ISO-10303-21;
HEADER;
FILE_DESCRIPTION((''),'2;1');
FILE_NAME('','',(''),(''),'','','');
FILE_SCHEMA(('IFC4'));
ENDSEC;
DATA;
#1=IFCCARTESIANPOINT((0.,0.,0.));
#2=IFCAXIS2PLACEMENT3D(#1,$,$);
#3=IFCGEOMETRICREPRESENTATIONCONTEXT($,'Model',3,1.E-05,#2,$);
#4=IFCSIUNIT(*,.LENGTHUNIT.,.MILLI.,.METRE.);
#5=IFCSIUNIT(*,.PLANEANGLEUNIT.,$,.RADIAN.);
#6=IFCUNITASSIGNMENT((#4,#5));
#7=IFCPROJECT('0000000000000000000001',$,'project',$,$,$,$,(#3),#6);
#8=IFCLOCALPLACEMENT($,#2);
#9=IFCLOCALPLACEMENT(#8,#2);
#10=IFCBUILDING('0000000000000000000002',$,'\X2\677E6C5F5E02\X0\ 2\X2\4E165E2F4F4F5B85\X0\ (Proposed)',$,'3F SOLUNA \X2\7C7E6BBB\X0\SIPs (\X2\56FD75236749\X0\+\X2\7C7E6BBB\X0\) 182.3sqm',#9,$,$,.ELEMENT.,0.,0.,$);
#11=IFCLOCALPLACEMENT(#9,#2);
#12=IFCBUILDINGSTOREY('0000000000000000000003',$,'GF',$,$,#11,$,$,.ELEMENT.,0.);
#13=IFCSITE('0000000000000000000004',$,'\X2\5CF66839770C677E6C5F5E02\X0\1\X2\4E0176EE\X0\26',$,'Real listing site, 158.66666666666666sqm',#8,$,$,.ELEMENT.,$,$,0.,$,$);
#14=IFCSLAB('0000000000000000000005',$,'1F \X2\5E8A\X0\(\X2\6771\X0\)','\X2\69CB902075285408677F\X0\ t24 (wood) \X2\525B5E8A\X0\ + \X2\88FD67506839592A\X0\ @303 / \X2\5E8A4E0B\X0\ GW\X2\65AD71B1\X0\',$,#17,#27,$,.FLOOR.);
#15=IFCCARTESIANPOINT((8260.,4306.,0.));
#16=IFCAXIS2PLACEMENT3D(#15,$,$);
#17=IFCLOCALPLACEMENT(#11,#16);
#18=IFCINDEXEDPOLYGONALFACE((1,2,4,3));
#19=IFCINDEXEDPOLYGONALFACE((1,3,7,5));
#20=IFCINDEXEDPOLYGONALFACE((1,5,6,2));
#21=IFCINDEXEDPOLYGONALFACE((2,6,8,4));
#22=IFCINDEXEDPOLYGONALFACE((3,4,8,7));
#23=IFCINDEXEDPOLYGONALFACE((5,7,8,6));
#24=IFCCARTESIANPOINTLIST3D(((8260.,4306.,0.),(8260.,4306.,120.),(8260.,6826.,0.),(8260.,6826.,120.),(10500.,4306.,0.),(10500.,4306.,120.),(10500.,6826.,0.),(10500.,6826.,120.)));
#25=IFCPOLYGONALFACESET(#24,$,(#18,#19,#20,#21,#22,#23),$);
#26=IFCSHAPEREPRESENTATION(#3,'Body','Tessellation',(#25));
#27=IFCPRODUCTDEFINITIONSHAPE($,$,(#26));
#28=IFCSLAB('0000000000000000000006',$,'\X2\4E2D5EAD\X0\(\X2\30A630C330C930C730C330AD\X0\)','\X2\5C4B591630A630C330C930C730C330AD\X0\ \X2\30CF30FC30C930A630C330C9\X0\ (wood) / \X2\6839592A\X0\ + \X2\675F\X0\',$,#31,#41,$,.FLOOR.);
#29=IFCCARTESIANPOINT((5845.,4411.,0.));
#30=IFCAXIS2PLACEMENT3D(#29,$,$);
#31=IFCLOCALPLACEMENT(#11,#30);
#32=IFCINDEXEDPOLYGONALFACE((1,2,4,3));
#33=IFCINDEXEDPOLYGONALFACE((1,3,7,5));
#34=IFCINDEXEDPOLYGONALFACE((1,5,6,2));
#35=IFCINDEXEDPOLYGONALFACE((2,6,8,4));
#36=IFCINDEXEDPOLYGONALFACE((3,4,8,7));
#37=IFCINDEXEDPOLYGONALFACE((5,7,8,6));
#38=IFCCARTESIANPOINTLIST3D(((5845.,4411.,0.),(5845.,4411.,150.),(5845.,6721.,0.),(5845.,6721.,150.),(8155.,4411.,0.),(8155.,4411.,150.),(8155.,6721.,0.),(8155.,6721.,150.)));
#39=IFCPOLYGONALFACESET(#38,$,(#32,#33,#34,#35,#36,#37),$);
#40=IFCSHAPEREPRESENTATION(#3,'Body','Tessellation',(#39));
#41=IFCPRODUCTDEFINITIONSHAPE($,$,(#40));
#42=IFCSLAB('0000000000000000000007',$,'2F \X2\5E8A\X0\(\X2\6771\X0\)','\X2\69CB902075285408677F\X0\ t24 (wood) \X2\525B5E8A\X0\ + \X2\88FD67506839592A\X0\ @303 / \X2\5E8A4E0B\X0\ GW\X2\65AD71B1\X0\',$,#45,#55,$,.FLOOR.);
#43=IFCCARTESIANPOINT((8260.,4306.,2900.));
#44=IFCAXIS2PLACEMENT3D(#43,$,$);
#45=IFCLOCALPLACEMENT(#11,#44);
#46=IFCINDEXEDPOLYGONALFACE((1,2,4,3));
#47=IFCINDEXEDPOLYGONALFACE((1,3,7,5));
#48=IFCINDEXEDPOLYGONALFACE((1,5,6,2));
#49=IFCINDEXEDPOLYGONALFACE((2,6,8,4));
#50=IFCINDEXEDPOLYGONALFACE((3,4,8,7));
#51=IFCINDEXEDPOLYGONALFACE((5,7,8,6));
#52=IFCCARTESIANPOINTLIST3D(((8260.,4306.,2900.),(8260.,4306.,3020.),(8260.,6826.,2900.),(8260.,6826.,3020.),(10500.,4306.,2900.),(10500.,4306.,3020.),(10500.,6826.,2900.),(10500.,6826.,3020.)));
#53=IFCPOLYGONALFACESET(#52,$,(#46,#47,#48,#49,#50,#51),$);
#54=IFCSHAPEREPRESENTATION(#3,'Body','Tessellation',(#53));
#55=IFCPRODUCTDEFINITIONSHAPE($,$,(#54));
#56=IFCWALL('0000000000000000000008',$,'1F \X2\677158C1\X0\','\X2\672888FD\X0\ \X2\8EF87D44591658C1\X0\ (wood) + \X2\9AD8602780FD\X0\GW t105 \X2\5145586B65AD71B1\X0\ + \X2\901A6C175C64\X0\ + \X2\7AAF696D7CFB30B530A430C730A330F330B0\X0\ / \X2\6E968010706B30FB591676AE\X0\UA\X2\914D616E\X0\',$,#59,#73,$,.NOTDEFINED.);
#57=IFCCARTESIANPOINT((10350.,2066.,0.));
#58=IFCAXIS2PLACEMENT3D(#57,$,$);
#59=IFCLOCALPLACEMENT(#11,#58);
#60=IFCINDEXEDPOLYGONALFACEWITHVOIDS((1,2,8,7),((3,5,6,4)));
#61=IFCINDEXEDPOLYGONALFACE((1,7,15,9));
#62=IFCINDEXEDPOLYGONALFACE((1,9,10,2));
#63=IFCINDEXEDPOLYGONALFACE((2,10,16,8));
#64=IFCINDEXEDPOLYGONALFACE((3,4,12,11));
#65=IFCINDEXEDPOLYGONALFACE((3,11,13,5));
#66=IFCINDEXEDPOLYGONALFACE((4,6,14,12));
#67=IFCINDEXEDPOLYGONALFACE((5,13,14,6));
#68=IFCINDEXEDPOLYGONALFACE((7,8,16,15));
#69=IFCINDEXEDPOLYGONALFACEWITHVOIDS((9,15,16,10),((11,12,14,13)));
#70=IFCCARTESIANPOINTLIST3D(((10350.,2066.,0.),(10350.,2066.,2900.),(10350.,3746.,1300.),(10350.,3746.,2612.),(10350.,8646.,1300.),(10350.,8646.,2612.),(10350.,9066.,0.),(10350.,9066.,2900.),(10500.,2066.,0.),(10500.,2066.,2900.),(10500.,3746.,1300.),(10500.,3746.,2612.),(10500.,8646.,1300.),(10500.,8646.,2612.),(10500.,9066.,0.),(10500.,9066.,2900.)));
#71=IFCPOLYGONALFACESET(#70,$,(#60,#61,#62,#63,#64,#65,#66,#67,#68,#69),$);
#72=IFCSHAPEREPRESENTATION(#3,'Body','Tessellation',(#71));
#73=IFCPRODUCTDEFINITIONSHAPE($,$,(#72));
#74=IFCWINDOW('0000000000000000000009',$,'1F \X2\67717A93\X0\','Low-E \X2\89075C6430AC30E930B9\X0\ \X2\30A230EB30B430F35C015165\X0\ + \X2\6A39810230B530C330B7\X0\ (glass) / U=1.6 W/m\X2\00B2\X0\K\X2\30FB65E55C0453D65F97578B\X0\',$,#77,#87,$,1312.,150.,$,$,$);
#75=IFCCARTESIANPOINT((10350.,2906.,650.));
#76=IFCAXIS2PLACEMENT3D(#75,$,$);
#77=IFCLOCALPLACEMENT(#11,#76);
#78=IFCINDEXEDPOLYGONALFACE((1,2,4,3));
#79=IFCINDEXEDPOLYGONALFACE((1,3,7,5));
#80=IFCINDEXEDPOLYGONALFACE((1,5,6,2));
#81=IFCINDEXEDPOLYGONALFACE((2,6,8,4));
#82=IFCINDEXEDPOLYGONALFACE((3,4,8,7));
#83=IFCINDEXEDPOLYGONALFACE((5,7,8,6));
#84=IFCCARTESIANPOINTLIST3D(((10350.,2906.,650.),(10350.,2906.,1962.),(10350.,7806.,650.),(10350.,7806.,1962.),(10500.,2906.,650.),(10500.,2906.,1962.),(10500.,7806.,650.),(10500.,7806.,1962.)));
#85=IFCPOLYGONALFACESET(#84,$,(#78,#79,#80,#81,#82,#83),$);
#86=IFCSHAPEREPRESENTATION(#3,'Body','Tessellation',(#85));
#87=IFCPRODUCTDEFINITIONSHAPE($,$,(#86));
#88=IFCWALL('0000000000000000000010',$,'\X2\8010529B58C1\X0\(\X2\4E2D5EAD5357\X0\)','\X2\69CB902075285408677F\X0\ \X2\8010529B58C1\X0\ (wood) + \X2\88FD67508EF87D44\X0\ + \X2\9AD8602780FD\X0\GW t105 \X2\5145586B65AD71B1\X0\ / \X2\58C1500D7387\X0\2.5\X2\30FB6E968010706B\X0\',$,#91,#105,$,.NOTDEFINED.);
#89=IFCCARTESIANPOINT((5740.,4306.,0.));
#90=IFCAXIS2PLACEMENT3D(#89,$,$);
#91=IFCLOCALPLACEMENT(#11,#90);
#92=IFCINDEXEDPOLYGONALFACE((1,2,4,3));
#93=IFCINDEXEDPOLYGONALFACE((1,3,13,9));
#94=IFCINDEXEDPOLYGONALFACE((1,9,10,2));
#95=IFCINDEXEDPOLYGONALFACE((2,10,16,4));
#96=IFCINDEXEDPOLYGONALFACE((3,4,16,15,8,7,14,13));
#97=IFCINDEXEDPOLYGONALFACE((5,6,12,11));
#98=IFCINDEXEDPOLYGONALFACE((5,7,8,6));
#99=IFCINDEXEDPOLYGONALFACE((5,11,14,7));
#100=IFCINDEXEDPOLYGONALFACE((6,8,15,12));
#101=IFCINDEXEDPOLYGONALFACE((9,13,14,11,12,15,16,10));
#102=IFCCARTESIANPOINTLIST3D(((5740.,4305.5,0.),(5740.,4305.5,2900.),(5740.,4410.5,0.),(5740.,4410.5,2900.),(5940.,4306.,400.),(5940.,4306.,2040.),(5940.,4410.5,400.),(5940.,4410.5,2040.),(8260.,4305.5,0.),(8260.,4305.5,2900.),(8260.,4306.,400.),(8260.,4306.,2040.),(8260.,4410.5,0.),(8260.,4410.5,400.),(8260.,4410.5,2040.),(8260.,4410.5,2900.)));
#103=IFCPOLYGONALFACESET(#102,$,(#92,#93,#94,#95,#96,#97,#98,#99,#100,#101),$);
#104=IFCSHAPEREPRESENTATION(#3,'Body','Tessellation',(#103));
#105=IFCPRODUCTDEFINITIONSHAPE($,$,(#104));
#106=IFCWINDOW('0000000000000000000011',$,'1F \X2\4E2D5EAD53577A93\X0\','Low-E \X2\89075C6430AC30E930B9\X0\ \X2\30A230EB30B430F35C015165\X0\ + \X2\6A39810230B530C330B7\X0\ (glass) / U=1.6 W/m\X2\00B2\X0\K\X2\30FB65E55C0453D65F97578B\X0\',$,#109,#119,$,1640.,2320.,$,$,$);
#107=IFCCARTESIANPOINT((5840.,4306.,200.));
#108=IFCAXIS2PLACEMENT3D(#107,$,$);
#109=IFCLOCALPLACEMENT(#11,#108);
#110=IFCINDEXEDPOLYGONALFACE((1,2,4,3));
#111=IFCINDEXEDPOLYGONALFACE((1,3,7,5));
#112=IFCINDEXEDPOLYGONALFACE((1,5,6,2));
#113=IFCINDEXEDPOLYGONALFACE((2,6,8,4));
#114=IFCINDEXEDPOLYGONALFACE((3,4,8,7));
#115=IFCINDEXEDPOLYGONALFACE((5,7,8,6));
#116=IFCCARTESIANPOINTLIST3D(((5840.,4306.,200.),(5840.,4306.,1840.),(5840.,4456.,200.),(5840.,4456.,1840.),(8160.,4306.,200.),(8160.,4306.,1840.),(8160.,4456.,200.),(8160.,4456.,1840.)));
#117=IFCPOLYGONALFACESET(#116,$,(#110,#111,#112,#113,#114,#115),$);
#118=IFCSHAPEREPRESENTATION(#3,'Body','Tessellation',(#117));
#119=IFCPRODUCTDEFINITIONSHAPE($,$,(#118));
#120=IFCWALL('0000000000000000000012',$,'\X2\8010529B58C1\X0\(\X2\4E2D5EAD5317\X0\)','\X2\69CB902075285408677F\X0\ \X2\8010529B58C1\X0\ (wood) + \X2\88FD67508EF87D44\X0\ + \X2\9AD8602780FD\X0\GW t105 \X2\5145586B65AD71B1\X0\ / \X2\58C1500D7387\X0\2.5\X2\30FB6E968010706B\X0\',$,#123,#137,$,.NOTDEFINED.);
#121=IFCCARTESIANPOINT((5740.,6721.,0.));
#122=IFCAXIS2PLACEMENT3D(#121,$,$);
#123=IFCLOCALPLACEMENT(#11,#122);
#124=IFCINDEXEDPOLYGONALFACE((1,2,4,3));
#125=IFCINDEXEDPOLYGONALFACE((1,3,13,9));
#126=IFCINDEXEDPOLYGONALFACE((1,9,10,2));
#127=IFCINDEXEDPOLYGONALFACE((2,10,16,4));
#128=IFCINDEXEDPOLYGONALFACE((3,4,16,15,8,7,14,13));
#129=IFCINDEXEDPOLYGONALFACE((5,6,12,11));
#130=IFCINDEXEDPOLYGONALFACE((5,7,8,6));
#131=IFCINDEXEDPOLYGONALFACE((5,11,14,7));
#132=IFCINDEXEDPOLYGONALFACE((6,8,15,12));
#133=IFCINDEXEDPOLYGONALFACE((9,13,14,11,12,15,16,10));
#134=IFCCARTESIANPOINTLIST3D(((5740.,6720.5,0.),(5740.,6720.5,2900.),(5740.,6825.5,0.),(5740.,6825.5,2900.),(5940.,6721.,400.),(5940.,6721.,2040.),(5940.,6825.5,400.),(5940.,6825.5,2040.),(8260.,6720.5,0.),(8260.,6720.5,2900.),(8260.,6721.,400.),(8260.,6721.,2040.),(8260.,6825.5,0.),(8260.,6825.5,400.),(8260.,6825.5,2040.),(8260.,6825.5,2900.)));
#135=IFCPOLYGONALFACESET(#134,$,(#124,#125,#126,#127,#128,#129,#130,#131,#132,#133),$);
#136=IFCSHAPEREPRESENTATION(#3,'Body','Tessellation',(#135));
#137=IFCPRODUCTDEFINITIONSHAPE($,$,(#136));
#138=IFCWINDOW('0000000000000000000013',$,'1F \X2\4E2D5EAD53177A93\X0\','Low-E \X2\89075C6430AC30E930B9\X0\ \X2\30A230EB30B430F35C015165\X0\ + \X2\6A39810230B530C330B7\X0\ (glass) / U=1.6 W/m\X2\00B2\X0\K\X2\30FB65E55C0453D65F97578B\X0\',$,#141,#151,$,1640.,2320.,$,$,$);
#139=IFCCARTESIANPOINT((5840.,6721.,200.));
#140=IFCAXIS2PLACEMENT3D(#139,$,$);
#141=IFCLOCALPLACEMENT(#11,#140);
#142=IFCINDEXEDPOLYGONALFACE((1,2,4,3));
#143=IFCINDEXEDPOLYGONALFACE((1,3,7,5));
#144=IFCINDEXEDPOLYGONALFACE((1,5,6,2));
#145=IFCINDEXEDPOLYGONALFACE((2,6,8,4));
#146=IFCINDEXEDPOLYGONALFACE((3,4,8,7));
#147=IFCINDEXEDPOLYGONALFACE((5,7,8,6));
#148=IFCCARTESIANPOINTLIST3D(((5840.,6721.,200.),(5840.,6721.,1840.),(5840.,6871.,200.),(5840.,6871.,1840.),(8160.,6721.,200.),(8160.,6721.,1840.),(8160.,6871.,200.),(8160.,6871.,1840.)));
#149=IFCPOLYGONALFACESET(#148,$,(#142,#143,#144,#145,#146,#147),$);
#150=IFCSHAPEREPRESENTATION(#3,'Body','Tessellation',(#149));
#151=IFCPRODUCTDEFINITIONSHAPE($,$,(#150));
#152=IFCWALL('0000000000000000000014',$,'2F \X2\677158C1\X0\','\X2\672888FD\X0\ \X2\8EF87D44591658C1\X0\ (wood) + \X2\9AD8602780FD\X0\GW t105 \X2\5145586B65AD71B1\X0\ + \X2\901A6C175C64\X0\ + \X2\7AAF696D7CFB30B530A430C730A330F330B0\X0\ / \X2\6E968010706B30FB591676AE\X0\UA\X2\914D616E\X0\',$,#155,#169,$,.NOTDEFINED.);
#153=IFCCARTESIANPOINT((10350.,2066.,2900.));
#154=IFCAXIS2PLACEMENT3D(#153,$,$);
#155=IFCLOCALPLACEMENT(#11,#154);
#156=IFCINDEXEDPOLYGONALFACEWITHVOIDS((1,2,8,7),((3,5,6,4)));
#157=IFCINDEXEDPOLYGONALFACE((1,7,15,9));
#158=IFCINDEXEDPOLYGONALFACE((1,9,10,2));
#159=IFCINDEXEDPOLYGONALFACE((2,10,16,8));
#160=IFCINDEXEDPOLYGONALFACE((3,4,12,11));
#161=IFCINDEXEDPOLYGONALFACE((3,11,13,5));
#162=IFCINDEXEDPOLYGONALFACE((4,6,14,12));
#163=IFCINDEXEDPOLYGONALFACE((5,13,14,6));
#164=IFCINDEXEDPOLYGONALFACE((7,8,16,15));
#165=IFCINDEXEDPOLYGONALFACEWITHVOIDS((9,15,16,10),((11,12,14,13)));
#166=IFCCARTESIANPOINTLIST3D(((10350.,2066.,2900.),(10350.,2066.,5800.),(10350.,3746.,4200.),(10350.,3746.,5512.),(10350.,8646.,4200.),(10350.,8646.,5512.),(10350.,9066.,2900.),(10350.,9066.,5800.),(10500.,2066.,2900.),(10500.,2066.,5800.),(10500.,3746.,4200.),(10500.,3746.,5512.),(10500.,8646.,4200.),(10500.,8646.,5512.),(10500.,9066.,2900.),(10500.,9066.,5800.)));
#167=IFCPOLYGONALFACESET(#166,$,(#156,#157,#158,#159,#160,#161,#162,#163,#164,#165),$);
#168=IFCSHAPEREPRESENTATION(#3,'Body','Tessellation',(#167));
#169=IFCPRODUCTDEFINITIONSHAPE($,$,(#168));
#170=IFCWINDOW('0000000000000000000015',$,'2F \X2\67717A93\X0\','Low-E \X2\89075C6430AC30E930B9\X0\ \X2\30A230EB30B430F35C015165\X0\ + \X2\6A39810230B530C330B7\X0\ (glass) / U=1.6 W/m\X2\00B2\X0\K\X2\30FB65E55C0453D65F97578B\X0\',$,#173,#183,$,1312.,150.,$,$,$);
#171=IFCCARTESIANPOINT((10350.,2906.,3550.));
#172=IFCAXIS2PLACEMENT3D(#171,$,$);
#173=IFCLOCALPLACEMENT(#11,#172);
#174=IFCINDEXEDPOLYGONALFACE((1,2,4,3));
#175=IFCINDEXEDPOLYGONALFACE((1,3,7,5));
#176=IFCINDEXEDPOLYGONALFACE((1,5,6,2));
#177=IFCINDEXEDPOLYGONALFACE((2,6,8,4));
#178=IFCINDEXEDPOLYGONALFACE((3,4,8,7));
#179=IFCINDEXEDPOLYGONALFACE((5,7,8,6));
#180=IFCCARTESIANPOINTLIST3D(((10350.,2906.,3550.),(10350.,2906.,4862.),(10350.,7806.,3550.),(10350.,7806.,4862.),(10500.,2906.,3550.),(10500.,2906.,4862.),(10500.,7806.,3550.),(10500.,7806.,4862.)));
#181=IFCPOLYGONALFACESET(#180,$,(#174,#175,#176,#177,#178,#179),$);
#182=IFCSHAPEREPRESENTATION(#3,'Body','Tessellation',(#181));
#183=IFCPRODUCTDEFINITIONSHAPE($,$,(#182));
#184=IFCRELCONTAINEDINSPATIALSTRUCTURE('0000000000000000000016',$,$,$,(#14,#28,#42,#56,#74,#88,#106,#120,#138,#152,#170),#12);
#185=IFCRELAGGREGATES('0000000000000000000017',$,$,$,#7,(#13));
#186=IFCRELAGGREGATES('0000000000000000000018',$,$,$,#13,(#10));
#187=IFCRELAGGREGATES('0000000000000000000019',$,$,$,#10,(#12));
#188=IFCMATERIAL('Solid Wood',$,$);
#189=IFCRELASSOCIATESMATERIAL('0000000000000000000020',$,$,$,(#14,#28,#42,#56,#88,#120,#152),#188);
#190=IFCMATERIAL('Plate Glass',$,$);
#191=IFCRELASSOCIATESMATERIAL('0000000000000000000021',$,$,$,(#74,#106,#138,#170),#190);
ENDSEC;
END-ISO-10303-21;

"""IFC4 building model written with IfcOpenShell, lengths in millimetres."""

from ifc_helpers import new_model, si_unit, frame, frame_2d, origin, place, context, project, spatial, rectangle, extrude, material, element, fill, save


model = new_model("IFC4")

# Units and contexts
model_context = context("Model", 3, precision=1e-05, world=origin())
ifc_project = project(units=[si_unit("LENGTHUNIT", "METRE", prefix="MILLI"), si_unit("PLANEANGLEUNIT", "RADIAN")], contexts=[model_context])

# Site, building, storey
site_placement = place(None, origin())
site = spatial("IfcSite", under=ifc_project, at=site_placement, Name="島根県松江市1丁目26", ObjectType="Real listing site, 158.66666666666666sqm", CompositionType="ELEMENT", RefElevation=0.0)
building_placement = place(site_placement, origin())
building = spatial("IfcBuilding", under=site, at=building_placement, Name="松江市 2世帯住宅 (Proposed)", ObjectType="3F SOLUNA 籾殻SIPs (国産杉+籾殻) 182.3sqm", CompositionType="ELEMENT", ElevationOfRefHeight=0.0, ElevationOfTerrain=0.0)
storey_placement = place(building_placement, origin())
storey = spatial("IfcBuildingStorey", under=building, at=storey_placement, Name="GF", CompositionType="ELEMENT", Elevation=0.0)

# Slabs
ifc_material_1 = material(Name="Solid Wood")
slab_1_placement = place(storey_placement, frame((8260.0, 4306.0, 0.0)))
element("IfcSlab", 1, at=slab_1_placement, inside=storey, material=ifc_material_1, Name="1F 床(東)", Description="構造用合板 t24 (wood) 剛床 + 製材根太 @303 / 床下 GW断熱", PredefinedType="FLOOR", context=model_context, shape_type="SweptSolid", body=[
    extrude(rectangle(XDim=2240.0, YDim=2520.0, at=frame_2d((1120.0, 1260.0))), frame((8260.0, 4306.0, 0.0)), (0.0, 0.0, 1.0), 120.0),
])
slab_2_placement = place(storey_placement, frame((5845.0, 4411.0, 0.0)))
element("IfcSlab", 2, at=slab_2_placement, inside=storey, material=ifc_material_1, Name="中庭(ウッドデッキ)", Description="屋外ウッドデッキ ハードウッド (wood) / 根太 + 束", PredefinedType="FLOOR", context=model_context, shape_type="SweptSolid", body=[
    extrude(rectangle(XDim=2310.0, YDim=2310.0, at=frame_2d((1155.0, 1155.0))), frame((5845.0, 4411.0, 0.0)), (0.0, 0.0, 1.0), 150.0),
])
slab_3_placement = place(storey_placement, frame((8260.0, 4306.0, 2900.0)))
element("IfcSlab", 3, at=slab_3_placement, inside=storey, material=ifc_material_1, Name="2F 床(東)", Description="構造用合板 t24 (wood) 剛床 + 製材根太 @303 / 床下 GW断熱", PredefinedType="FLOOR", context=model_context, shape_type="SweptSolid", body=[
    extrude(rectangle(XDim=2240.0, YDim=2520.0, at=frame_2d((1120.0, 1260.0))), frame((8260.0, 4306.0, 2900.0)), (0.0, 0.0, 1.0), 120.0),
])

# Walls, openings, windows
wall_1_placement = place(storey_placement, frame((10350.0, 2066.0, 0.0)))
wall_1 = element("IfcWall", 4, at=wall_1_placement, inside=storey, material=ifc_material_1, Name="1F 東壁", Description="木製 軸組外壁 (wood) + 高性能GW t105 充填断熱 + 通気層 + 窯業系サイディング / 準耐火・外皮UA配慮", PredefinedType="NOTDEFINED", context=model_context, shape_type="SweptSolid", body=[
    extrude(rectangle(XDim=150.0, YDim=7000.0, at=frame_2d((75.0, 3500.0))), frame((10350.0, 2066.0, 0.0)), (0.0, 0.0, 1.0), 2900.0),
])
opening_1_placement = place(storey_placement, frame((10350.0, 2906.0, 650.0)))
opening_1 = element("IfcOpeningElement", 5, at=opening_1_placement, cuts=wall_1, PredefinedType="NOTDEFINED", context=model_context, shape_type="SweptSolid", body=[
    extrude(rectangle(XDim=150.0, YDim=4900.0, at=frame_2d((75.0, 2450.0))), frame((10350.0, 2906.0, 650.0)), (0.0, 0.0, 1.0), 1312.0),
])
ifc_material_2 = material(Name="Plate Glass")
window_1_placement = place(storey_placement, frame((10350.0, 2906.0, 650.0)))
window_1 = element("IfcWindow", 6, at=window_1_placement, inside=storey, material=ifc_material_2, Name="1F 東窓", Description="Low-E 複層ガラス アルゴン封入 + 樹脂サッシ (glass) / U=1.6 W/m²K・日射取得型", OverallHeight=1312.0, OverallWidth=150.0, context=model_context, shape_type="SweptSolid", body=[
    extrude(rectangle(XDim=150.0, YDim=4900.0, at=frame_2d((75.0, 2450.0))), frame((10350.0, 2906.0, 650.0)), (0.0, 0.0, 1.0), 1312.0),
])
fill(opening_1, window_1)
wall_2_placement = place(storey_placement, frame((5740.0, 4306.0, 0.0)))
wall_2 = element("IfcWall", 7, at=wall_2_placement, inside=storey, material=ifc_material_1, Name="耐力壁(中庭南)", Description="構造用合板 耐力壁 (wood) + 製材軸組 + 高性能GW t105 充填断熱 / 壁倍率2.5・準耐火", PredefinedType="NOTDEFINED", context=model_context, shape_type="SweptSolid", body=[
    extrude(rectangle(XDim=2520.0, YDim=105.0, at=frame_2d((1260.0, 52.0))), frame((5740.0, 4306.0, 0.0)), (0.0, 0.0, 1.0), 2900.0),
])
opening_2_placement = place(storey_placement, frame((5840.0, 4306.0, 200.0)))
opening_2 = element("IfcOpeningElement", 8, at=opening_2_placement, cuts=wall_2, PredefinedType="NOTDEFINED", context=model_context, shape_type="SweptSolid", body=[
    extrude(rectangle(XDim=2320.0, YDim=150.0, at=frame_2d((1160.0, 75.0))), frame((5840.0, 4306.0, 200.0)), (0.0, 0.0, 1.0), 1640.0),
])
window_2_placement = place(storey_placement, frame((5840.0, 4306.0, 200.0)))
window_2 = element("IfcWindow", 9, at=window_2_placement, inside=storey, material=ifc_material_2, Name="1F 中庭南窓", Description="Low-E 複層ガラス アルゴン封入 + 樹脂サッシ (glass) / U=1.6 W/m²K・日射取得型", OverallHeight=1640.0, OverallWidth=2320.0, context=model_context, shape_type="SweptSolid", body=[
    extrude(rectangle(XDim=2320.0, YDim=150.0, at=frame_2d((1160.0, 75.0))), frame((5840.0, 4306.0, 200.0)), (0.0, 0.0, 1.0), 1640.0),
])
fill(opening_2, window_2)
wall_3_placement = place(storey_placement, frame((5740.0, 6721.0, 0.0)))
wall_3 = element("IfcWall", 10, at=wall_3_placement, inside=storey, material=ifc_material_1, Name="耐力壁(中庭北)", Description="構造用合板 耐力壁 (wood) + 製材軸組 + 高性能GW t105 充填断熱 / 壁倍率2.5・準耐火", PredefinedType="NOTDEFINED", context=model_context, shape_type="SweptSolid", body=[
    extrude(rectangle(XDim=2520.0, YDim=105.0, at=frame_2d((1260.0, 52.0))), frame((5740.0, 6721.0, 0.0)), (0.0, 0.0, 1.0), 2900.0),
])
opening_3_placement = place(storey_placement, frame((5840.0, 6721.0, 200.0)))
opening_3 = element("IfcOpeningElement", 11, at=opening_3_placement, cuts=wall_3, PredefinedType="NOTDEFINED", context=model_context, shape_type="SweptSolid", body=[
    extrude(rectangle(XDim=2320.0, YDim=150.0, at=frame_2d((1160.0, 75.0))), frame((5840.0, 6721.0, 200.0)), (0.0, 0.0, 1.0), 1640.0),
])
window_3_placement = place(storey_placement, frame((5840.0, 6721.0, 200.0)))
window_3 = element("IfcWindow", 12, at=window_3_placement, inside=storey, material=ifc_material_2, Name="1F 中庭北窓", Description="Low-E 複層ガラス アルゴン封入 + 樹脂サッシ (glass) / U=1.6 W/m²K・日射取得型", OverallHeight=1640.0, OverallWidth=2320.0, context=model_context, shape_type="SweptSolid", body=[
    extrude(rectangle(XDim=2320.0, YDim=150.0, at=frame_2d((1160.0, 75.0))), frame((5840.0, 6721.0, 200.0)), (0.0, 0.0, 1.0), 1640.0),
])
fill(opening_3, window_3)

# Wall, opening, window
wall_4_placement = place(storey_placement, frame((10350.0, 2066.0, 2900.0)))
wall_4 = element("IfcWall", 13, at=wall_4_placement, inside=storey, material=ifc_material_1, Name="2F 東壁", Description="木製 軸組外壁 (wood) + 高性能GW t105 充填断熱 + 通気層 + 窯業系サイディング / 準耐火・外皮UA配慮", PredefinedType="NOTDEFINED", context=model_context, shape_type="SweptSolid", body=[
    extrude(rectangle(XDim=150.0, YDim=7000.0, at=frame_2d((75.0, 3500.0))), frame((10350.0, 2066.0, 2900.0)), (0.0, 0.0, 1.0), 2900.0),
])
opening_4_placement = place(storey_placement, frame((10350.0, 2906.0, 3550.0)))
opening_4 = element("IfcOpeningElement", 14, at=opening_4_placement, cuts=wall_4, PredefinedType="NOTDEFINED", context=model_context, shape_type="SweptSolid", body=[
    extrude(rectangle(XDim=150.0, YDim=4900.0, at=frame_2d((75.0, 2450.0))), frame((10350.0, 2906.0, 3550.0)), (0.0, 0.0, 1.0), 1312.0),
])
window_4_placement = place(storey_placement, frame((10350.0, 2906.0, 3550.0)))
window_4 = element("IfcWindow", 15, at=window_4_placement, inside=storey, material=ifc_material_2, Name="2F 東窓", Description="Low-E 複層ガラス アルゴン封入 + 樹脂サッシ (glass) / U=1.6 W/m²K・日射取得型", OverallHeight=1312.0, OverallWidth=150.0, context=model_context, shape_type="SweptSolid", body=[
    extrude(rectangle(XDim=150.0, YDim=4900.0, at=frame_2d((75.0, 2450.0))), frame((10350.0, 2906.0, 3550.0)), (0.0, 0.0, 1.0), 1312.0),
])
fill(opening_4, window_4)

save(model, "model.ifc")
